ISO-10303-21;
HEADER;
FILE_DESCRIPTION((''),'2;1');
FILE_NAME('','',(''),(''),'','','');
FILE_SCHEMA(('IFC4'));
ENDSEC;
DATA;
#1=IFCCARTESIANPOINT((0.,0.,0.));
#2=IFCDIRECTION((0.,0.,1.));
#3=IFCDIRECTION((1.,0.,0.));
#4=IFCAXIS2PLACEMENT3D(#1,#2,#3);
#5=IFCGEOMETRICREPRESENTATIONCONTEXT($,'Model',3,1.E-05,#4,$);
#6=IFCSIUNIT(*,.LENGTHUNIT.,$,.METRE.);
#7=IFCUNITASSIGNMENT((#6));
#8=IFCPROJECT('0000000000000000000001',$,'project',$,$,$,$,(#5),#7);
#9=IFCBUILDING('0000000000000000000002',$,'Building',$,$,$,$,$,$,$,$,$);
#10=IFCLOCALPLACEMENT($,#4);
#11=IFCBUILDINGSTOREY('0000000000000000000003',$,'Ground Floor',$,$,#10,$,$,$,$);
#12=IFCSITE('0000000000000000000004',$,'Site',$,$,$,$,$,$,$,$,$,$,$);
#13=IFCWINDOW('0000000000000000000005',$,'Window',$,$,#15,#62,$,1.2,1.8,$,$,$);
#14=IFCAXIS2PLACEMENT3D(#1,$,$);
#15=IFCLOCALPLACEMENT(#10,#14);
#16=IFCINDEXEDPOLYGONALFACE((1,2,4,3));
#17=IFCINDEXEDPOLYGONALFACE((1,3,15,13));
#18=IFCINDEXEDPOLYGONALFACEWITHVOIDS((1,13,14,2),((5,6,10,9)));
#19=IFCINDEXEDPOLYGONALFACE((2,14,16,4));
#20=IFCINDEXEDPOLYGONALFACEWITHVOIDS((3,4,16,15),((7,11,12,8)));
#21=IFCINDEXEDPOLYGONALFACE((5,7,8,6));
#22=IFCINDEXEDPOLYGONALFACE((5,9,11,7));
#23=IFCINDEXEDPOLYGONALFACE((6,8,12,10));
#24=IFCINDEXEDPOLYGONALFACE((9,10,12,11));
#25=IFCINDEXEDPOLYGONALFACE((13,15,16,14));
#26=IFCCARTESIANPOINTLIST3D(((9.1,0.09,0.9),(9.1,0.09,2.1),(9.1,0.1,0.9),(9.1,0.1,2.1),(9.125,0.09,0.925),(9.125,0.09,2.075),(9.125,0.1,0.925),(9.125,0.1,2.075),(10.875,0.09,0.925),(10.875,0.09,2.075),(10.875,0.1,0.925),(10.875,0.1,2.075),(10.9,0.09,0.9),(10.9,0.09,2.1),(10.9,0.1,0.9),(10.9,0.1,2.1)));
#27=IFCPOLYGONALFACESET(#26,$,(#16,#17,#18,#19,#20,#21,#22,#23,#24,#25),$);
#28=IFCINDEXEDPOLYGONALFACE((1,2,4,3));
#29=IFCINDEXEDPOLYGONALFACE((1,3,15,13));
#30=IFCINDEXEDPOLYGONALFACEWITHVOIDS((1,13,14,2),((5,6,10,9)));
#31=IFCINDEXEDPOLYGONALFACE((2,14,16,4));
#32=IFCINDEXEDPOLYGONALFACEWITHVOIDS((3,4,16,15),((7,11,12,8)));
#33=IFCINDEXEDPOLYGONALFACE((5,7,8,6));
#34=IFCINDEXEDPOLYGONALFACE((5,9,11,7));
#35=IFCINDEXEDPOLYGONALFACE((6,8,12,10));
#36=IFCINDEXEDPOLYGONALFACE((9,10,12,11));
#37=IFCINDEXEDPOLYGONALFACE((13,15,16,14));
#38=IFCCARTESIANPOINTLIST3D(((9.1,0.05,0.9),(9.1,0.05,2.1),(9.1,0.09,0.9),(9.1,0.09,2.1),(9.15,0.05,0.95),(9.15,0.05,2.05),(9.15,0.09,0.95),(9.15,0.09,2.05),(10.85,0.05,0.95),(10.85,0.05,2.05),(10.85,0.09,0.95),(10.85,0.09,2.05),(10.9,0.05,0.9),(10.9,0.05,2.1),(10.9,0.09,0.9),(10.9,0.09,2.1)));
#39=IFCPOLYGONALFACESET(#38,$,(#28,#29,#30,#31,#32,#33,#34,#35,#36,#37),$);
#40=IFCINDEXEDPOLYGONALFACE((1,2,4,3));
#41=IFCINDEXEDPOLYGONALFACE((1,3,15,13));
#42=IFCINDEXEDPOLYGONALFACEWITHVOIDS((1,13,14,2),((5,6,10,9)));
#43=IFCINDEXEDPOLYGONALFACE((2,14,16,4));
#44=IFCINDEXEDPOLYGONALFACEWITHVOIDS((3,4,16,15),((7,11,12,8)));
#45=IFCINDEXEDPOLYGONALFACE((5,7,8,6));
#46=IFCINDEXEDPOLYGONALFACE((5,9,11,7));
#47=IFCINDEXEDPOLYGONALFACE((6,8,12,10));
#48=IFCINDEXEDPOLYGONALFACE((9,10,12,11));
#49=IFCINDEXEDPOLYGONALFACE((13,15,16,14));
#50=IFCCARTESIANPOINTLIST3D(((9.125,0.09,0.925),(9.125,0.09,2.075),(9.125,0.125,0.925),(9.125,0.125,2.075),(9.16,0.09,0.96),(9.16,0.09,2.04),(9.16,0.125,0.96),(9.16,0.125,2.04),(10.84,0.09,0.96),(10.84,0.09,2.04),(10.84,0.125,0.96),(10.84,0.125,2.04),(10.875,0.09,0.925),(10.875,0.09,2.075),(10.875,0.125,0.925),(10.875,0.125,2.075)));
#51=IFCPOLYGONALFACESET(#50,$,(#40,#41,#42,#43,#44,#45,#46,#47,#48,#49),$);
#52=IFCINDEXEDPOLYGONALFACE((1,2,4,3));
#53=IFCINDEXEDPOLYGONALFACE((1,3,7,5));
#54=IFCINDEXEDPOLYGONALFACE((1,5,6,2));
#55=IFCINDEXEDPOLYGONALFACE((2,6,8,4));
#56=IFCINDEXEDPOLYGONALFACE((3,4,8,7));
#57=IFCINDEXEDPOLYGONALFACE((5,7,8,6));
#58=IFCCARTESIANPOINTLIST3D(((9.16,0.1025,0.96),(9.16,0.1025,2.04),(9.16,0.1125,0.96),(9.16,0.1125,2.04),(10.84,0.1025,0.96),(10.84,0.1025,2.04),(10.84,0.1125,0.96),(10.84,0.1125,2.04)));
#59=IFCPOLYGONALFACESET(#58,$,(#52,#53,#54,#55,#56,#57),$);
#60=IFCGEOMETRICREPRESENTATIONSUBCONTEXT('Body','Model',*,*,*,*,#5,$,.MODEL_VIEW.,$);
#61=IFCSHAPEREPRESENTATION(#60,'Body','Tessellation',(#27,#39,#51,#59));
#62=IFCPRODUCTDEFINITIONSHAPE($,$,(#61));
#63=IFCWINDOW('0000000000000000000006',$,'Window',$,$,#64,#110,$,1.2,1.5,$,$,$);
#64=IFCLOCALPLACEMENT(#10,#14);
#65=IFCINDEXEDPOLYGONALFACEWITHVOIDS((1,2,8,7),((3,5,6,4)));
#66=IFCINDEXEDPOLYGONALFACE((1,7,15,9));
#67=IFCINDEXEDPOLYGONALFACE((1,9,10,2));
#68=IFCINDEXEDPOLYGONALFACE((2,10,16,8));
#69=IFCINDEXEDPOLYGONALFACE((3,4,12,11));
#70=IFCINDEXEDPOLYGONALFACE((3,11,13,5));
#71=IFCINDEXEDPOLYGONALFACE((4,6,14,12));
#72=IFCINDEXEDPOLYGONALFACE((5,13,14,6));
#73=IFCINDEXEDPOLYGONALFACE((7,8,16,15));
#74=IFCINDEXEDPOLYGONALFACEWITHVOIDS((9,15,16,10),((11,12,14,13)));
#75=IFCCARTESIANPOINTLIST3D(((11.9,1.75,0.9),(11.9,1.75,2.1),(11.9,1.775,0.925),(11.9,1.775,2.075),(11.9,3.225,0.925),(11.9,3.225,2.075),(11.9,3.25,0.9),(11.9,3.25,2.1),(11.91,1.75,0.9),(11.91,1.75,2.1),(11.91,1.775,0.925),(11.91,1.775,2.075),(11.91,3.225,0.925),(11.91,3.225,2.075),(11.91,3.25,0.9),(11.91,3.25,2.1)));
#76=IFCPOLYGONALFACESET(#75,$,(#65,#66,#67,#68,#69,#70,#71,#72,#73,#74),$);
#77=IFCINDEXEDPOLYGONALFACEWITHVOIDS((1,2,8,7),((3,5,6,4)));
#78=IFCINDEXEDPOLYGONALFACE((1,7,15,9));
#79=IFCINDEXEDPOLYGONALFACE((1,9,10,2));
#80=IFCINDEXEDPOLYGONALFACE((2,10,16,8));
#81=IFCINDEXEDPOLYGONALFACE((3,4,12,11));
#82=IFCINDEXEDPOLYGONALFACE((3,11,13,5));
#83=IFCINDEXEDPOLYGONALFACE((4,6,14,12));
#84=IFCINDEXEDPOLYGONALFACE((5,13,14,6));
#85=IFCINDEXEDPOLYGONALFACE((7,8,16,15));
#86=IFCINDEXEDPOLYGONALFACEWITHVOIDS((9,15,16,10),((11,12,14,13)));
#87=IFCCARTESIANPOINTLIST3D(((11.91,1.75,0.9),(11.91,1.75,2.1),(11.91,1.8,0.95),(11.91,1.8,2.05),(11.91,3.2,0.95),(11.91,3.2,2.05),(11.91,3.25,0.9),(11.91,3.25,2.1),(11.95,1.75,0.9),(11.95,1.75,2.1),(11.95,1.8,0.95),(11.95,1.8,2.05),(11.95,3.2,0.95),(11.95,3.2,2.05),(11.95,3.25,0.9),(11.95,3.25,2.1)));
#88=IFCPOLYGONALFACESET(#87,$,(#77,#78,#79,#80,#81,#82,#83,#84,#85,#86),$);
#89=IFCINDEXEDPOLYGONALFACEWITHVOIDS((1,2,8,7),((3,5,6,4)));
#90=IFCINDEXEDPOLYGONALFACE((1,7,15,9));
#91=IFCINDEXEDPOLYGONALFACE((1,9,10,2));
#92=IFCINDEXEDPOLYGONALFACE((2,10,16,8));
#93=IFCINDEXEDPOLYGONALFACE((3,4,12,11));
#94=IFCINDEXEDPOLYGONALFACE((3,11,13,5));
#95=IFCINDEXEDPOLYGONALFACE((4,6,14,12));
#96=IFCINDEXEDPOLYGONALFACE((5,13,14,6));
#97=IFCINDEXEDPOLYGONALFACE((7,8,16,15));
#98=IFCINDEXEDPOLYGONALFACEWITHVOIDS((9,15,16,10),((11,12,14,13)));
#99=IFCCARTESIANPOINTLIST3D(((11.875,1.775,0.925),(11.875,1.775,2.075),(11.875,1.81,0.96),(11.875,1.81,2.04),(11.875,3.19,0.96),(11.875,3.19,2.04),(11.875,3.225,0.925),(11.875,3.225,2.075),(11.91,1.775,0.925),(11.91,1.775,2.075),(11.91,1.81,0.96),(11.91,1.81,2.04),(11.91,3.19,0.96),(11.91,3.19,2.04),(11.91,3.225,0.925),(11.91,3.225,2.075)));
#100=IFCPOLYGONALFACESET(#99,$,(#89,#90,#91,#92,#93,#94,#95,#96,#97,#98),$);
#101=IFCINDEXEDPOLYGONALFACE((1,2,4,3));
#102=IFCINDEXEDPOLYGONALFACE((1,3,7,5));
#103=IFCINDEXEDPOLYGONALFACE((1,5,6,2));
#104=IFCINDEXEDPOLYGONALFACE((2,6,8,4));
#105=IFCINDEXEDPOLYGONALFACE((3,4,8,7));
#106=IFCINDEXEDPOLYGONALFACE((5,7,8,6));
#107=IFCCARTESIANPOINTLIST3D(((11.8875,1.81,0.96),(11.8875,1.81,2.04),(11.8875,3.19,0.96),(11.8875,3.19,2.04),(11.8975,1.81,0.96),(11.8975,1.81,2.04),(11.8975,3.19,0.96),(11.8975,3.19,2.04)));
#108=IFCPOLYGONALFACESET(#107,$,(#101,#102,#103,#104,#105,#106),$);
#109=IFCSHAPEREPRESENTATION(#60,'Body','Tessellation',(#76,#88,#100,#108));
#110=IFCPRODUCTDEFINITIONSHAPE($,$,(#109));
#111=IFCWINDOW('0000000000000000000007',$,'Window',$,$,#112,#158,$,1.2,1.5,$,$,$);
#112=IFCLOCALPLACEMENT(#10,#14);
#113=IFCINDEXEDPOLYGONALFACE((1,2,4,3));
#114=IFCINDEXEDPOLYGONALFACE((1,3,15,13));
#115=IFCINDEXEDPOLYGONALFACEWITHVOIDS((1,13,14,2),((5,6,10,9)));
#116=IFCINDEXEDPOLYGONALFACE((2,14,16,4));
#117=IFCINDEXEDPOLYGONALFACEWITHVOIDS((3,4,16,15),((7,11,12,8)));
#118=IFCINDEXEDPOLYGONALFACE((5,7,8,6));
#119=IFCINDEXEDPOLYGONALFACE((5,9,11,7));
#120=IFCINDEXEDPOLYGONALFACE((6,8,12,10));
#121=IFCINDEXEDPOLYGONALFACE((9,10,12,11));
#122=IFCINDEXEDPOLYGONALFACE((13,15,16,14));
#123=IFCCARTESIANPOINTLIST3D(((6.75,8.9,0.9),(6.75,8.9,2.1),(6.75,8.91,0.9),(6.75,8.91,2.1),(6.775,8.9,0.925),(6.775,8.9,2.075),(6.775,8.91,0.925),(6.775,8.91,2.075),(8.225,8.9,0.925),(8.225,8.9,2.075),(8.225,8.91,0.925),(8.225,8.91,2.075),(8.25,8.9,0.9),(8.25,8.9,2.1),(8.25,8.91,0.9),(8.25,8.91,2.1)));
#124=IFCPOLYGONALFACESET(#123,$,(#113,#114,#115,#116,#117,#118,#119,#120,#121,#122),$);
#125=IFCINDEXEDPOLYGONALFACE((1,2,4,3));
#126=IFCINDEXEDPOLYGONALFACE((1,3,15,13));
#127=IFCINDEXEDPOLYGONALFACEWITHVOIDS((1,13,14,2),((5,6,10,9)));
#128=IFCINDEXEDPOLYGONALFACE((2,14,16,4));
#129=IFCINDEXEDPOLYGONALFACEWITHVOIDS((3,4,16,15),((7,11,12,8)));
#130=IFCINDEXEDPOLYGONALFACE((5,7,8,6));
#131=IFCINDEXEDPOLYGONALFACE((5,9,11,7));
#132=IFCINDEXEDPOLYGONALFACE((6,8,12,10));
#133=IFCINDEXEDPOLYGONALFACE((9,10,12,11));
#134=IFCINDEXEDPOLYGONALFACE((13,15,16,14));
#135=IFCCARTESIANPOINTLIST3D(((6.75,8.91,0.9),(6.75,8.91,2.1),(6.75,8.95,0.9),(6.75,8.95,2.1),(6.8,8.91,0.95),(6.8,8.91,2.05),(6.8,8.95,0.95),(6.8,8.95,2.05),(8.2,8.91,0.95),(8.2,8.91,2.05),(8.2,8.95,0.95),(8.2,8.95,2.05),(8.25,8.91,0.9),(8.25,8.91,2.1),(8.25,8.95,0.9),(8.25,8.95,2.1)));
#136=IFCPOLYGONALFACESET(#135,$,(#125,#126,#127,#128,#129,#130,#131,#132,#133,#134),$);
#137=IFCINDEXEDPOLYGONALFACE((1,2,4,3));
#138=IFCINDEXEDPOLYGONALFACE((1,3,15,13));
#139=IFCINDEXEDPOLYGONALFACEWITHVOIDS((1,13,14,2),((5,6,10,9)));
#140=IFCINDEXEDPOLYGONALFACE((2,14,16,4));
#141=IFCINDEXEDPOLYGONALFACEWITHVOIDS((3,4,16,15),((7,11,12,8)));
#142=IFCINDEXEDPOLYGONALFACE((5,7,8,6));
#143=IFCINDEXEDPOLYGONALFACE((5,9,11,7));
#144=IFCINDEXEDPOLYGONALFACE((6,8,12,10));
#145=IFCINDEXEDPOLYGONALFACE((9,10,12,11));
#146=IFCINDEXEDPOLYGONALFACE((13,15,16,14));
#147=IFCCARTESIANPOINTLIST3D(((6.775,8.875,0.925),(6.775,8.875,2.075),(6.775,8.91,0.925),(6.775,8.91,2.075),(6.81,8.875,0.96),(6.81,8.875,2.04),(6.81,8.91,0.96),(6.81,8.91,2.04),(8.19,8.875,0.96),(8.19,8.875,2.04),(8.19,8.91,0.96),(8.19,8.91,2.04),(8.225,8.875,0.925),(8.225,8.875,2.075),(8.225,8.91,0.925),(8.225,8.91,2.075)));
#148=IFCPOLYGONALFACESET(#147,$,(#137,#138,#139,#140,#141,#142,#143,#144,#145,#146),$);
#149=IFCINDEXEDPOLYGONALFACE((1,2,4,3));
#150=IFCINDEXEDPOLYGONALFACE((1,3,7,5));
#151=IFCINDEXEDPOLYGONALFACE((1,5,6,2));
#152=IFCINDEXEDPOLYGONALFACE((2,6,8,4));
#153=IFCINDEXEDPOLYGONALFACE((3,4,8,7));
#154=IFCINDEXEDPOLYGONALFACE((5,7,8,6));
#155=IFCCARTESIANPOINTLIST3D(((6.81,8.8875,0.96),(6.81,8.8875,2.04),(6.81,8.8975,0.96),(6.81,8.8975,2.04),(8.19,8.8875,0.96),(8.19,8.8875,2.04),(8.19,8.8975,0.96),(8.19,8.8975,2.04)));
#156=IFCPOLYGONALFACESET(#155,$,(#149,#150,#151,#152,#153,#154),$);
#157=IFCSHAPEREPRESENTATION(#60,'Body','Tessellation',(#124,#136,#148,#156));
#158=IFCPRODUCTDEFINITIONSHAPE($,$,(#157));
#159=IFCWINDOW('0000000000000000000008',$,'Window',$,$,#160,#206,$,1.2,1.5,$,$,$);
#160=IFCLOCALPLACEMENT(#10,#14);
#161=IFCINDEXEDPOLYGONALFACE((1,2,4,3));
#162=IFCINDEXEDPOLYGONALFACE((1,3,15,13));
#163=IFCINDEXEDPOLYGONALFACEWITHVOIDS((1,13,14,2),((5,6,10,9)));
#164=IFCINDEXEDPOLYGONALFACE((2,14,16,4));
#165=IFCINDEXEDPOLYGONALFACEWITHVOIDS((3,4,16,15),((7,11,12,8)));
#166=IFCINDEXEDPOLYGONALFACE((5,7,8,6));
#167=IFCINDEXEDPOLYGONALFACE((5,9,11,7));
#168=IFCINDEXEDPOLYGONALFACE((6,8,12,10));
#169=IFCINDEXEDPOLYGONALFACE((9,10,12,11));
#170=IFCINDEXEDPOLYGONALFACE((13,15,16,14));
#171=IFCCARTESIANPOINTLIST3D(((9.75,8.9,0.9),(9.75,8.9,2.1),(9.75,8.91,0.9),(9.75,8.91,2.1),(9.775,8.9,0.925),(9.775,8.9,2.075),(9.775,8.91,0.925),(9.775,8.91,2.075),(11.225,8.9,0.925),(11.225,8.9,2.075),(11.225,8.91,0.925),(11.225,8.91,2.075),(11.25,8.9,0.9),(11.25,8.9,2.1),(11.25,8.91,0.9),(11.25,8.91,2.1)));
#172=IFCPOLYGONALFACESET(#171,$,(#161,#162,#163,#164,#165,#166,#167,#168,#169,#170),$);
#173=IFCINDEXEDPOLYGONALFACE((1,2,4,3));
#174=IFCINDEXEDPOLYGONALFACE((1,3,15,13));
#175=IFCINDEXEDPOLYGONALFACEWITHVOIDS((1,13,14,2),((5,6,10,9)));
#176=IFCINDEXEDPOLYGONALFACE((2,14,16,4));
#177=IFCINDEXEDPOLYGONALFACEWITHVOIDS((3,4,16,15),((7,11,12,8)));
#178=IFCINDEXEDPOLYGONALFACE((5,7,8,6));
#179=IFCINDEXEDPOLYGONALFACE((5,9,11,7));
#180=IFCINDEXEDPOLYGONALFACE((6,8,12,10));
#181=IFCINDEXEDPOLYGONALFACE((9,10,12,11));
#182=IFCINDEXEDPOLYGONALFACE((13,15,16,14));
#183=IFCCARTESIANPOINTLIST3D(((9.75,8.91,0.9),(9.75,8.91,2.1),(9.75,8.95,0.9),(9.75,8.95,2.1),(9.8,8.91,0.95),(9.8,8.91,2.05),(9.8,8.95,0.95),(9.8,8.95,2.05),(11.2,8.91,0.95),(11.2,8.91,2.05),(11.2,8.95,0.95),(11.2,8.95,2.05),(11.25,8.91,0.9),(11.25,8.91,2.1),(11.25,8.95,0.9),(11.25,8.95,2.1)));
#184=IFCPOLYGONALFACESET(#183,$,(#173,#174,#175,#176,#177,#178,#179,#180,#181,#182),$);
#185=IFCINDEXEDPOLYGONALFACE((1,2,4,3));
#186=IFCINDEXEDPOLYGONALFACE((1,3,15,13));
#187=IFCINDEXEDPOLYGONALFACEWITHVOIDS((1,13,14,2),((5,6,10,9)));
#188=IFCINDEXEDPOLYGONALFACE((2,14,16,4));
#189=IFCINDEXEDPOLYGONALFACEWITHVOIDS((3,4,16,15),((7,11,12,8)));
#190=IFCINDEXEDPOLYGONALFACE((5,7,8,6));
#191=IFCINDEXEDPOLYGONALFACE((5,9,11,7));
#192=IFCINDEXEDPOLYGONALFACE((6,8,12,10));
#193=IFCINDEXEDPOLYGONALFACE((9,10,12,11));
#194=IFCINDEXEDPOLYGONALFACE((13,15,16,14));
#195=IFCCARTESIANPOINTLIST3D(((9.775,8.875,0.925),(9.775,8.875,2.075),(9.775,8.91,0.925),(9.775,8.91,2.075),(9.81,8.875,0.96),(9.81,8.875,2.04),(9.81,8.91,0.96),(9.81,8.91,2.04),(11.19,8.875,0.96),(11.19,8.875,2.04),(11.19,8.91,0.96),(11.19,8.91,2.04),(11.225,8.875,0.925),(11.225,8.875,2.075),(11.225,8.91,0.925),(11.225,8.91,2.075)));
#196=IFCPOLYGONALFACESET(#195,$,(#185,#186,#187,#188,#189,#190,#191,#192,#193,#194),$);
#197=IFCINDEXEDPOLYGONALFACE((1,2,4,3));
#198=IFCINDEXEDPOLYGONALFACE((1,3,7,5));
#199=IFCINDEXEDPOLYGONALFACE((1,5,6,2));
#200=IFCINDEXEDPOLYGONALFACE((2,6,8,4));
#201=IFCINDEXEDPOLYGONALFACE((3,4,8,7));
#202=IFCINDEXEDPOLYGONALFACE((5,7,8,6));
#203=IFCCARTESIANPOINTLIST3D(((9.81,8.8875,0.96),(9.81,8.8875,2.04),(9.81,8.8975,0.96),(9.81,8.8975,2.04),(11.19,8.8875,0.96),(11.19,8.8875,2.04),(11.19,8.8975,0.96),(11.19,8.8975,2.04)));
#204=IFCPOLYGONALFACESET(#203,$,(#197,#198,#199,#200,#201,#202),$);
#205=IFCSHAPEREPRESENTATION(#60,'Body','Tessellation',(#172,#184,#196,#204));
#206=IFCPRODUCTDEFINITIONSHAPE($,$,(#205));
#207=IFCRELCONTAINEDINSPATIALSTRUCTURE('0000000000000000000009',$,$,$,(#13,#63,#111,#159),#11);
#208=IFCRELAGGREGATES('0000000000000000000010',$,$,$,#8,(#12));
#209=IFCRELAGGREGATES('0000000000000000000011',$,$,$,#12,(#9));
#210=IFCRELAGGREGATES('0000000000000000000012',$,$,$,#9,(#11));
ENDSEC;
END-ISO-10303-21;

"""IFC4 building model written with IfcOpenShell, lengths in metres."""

from ifc_helpers import new_model, si_unit, frame, origin_with_axes, place, context, subcontext, project, spatial, line, indexed_curve, outline, extrude, element, save


model = new_model("IFC4")

# Units and contexts
model_context = context("Model", 3, precision=1e-05, world=origin_with_axes())
body_context = subcontext(model_context, "Body", "Model", "MODEL_VIEW")
ifc_project = project(units=[si_unit("LENGTHUNIT", "METRE")], contexts=[model_context])

# Site, building, storey
site = spatial("IfcSite", under=ifc_project, Name="Site")
building = spatial("IfcBuilding", under=site, Name="Building")
storey_placement = place(None, origin_with_axes())
storey = spatial("IfcBuildingStorey", under=building, at=storey_placement, Name="Ground Floor")

# Windows
window_1_placement = place(storey_placement, frame((9.1, 0.0, 0.9), z_axis=(0.0, 0.0, 1.0), x_axis=(1.0, 0.0, 0.0)))
element("IfcWindow", 1, at=window_1_placement, inside=storey, Name="Window", OverallHeight=1.2, OverallWidth=1.8, context=body_context, shape_type="SweptSolid", body=[
    extrude(outline(indexed_curve([(0.0, 0.0), (1.8, 0.0), (1.8, 1.2), (0.0, 1.2)], segments=[line(1, 2, 3, 4, 1)]), holes=[indexed_curve([(0.025, 0.025), (1.775, 0.025), (1.775, 1.175), (0.025, 1.175)], segments=[line(1, 2, 3, 4, 1)])]), frame((0.0, 0.09, 0.0), z_axis=(0.0, -1.0, 0.0), x_axis=(1.0, 0.0, 0.0)), (0.0, 0.0, -1.0), 0.01),
    extrude(outline(indexed_curve([(0.0, 0.0), (1.8, 0.0), (1.8, 1.2), (0.0, 1.2)], segments=[line(1, 2, 3, 4, 1)]), holes=[indexed_curve([(0.05, 0.05), (1.75, 0.05), (1.75, 1.15), (0.05, 1.15)], segments=[line(1, 2, 3, 4, 1)])]), frame((0.0, 0.05, 0.0), z_axis=(0.0, -1.0, 0.0), x_axis=(1.0, 0.0, 0.0)), (0.0, 0.0, -1.0), 0.04),
    extrude(outline(indexed_curve([(0.0, 0.0), (1.75, 0.0), (1.75, 1.15), (0.0, 1.15)], segments=[line(1, 2, 3, 4, 1)]), holes=[indexed_curve([(0.035, 0.035), (1.715, 0.035), (1.715, 1.115), (0.035, 1.115)], segments=[line(1, 2, 3, 4, 1)])]), frame((0.025, 0.09, 0.025), z_axis=(0.0, -1.0, 0.0), x_axis=(1.0, 0.0, 0.0)), (0.0, 0.0, -1.0), 0.035),
    extrude(outline(indexed_curve([(0.035, 0.035), (1.715, 0.035), (1.715, 1.115), (0.035, 1.115)], segments=[line(1, 2, 3, 4, 1)])), frame((0.025, 0.1025, 0.025), z_axis=(0.0, -1.0, 0.0), x_axis=(1.0, 0.0, 0.0)), (0.0, 0.0, -1.0), 0.01),
])
for number, where, z_axis, x_axis, name in (
    (2, (12.0, 1.75, 0.9), (0.0, 0.0, 1.0), (0.0, 1.0, 0.0), "Window"),
    (3, (8.25, 9.0, 0.9), (0.0, 0.0, 1.0), (-1.0, 0.0, 0.0), "Window"),
    (4, (11.25, 9.0, 0.9), (0.0, 0.0, 1.0), (-1.0, 0.0, 0.0), "Window"),
):
    element("IfcWindow", number, at=place(storey_placement, frame(where, z_axis=z_axis, x_axis=x_axis)), inside=storey, Name=name, OverallHeight=1.2, OverallWidth=1.5, context=body_context, shape_type="SweptSolid", body=[
        extrude(outline(indexed_curve([(0.0, 0.0), (1.5, 0.0), (1.5, 1.2), (0.0, 1.2)], segments=[line(1, 2, 3, 4, 1)]), holes=[indexed_curve([(0.025, 0.025), (1.475, 0.025), (1.475, 1.175), (0.025, 1.175)], segments=[line(1, 2, 3, 4, 1)])]), frame((0.0, 0.09, 0.0), z_axis=(0.0, -1.0, 0.0), x_axis=(1.0, 0.0, 0.0)), (0.0, 0.0, -1.0), 0.01),
        extrude(outline(indexed_curve([(0.0, 0.0), (1.5, 0.0), (1.5, 1.2), (0.0, 1.2)], segments=[line(1, 2, 3, 4, 1)]), holes=[indexed_curve([(0.05, 0.05), (1.45, 0.05), (1.45, 1.15), (0.05, 1.15)], segments=[line(1, 2, 3, 4, 1)])]), frame((0.0, 0.05, 0.0), z_axis=(0.0, -1.0, 0.0), x_axis=(1.0, 0.0, 0.0)), (0.0, 0.0, -1.0), 0.04),
        extrude(outline(indexed_curve([(0.0, 0.0), (1.45, 0.0), (1.45, 1.15), (0.0, 1.15)], segments=[line(1, 2, 3, 4, 1)]), holes=[indexed_curve([(0.035, 0.035), (1.415, 0.035), (1.415, 1.115), (0.035, 1.115)], segments=[line(1, 2, 3, 4, 1)])]), frame((0.025, 0.09, 0.025), z_axis=(0.0, -1.0, 0.0), x_axis=(1.0, 0.0, 0.0)), (0.0, 0.0, -1.0), 0.035),
        extrude(outline(indexed_curve([(0.035, 0.035), (1.415, 0.035), (1.415, 1.115), (0.035, 1.115)], segments=[line(1, 2, 3, 4, 1)])), frame((0.025, 0.1025, 0.025), z_axis=(0.0, -1.0, 0.0), x_axis=(1.0, 0.0, 0.0)), (0.0, 0.0, -1.0), 0.01),
    ])

save(model, "model.ifc")
